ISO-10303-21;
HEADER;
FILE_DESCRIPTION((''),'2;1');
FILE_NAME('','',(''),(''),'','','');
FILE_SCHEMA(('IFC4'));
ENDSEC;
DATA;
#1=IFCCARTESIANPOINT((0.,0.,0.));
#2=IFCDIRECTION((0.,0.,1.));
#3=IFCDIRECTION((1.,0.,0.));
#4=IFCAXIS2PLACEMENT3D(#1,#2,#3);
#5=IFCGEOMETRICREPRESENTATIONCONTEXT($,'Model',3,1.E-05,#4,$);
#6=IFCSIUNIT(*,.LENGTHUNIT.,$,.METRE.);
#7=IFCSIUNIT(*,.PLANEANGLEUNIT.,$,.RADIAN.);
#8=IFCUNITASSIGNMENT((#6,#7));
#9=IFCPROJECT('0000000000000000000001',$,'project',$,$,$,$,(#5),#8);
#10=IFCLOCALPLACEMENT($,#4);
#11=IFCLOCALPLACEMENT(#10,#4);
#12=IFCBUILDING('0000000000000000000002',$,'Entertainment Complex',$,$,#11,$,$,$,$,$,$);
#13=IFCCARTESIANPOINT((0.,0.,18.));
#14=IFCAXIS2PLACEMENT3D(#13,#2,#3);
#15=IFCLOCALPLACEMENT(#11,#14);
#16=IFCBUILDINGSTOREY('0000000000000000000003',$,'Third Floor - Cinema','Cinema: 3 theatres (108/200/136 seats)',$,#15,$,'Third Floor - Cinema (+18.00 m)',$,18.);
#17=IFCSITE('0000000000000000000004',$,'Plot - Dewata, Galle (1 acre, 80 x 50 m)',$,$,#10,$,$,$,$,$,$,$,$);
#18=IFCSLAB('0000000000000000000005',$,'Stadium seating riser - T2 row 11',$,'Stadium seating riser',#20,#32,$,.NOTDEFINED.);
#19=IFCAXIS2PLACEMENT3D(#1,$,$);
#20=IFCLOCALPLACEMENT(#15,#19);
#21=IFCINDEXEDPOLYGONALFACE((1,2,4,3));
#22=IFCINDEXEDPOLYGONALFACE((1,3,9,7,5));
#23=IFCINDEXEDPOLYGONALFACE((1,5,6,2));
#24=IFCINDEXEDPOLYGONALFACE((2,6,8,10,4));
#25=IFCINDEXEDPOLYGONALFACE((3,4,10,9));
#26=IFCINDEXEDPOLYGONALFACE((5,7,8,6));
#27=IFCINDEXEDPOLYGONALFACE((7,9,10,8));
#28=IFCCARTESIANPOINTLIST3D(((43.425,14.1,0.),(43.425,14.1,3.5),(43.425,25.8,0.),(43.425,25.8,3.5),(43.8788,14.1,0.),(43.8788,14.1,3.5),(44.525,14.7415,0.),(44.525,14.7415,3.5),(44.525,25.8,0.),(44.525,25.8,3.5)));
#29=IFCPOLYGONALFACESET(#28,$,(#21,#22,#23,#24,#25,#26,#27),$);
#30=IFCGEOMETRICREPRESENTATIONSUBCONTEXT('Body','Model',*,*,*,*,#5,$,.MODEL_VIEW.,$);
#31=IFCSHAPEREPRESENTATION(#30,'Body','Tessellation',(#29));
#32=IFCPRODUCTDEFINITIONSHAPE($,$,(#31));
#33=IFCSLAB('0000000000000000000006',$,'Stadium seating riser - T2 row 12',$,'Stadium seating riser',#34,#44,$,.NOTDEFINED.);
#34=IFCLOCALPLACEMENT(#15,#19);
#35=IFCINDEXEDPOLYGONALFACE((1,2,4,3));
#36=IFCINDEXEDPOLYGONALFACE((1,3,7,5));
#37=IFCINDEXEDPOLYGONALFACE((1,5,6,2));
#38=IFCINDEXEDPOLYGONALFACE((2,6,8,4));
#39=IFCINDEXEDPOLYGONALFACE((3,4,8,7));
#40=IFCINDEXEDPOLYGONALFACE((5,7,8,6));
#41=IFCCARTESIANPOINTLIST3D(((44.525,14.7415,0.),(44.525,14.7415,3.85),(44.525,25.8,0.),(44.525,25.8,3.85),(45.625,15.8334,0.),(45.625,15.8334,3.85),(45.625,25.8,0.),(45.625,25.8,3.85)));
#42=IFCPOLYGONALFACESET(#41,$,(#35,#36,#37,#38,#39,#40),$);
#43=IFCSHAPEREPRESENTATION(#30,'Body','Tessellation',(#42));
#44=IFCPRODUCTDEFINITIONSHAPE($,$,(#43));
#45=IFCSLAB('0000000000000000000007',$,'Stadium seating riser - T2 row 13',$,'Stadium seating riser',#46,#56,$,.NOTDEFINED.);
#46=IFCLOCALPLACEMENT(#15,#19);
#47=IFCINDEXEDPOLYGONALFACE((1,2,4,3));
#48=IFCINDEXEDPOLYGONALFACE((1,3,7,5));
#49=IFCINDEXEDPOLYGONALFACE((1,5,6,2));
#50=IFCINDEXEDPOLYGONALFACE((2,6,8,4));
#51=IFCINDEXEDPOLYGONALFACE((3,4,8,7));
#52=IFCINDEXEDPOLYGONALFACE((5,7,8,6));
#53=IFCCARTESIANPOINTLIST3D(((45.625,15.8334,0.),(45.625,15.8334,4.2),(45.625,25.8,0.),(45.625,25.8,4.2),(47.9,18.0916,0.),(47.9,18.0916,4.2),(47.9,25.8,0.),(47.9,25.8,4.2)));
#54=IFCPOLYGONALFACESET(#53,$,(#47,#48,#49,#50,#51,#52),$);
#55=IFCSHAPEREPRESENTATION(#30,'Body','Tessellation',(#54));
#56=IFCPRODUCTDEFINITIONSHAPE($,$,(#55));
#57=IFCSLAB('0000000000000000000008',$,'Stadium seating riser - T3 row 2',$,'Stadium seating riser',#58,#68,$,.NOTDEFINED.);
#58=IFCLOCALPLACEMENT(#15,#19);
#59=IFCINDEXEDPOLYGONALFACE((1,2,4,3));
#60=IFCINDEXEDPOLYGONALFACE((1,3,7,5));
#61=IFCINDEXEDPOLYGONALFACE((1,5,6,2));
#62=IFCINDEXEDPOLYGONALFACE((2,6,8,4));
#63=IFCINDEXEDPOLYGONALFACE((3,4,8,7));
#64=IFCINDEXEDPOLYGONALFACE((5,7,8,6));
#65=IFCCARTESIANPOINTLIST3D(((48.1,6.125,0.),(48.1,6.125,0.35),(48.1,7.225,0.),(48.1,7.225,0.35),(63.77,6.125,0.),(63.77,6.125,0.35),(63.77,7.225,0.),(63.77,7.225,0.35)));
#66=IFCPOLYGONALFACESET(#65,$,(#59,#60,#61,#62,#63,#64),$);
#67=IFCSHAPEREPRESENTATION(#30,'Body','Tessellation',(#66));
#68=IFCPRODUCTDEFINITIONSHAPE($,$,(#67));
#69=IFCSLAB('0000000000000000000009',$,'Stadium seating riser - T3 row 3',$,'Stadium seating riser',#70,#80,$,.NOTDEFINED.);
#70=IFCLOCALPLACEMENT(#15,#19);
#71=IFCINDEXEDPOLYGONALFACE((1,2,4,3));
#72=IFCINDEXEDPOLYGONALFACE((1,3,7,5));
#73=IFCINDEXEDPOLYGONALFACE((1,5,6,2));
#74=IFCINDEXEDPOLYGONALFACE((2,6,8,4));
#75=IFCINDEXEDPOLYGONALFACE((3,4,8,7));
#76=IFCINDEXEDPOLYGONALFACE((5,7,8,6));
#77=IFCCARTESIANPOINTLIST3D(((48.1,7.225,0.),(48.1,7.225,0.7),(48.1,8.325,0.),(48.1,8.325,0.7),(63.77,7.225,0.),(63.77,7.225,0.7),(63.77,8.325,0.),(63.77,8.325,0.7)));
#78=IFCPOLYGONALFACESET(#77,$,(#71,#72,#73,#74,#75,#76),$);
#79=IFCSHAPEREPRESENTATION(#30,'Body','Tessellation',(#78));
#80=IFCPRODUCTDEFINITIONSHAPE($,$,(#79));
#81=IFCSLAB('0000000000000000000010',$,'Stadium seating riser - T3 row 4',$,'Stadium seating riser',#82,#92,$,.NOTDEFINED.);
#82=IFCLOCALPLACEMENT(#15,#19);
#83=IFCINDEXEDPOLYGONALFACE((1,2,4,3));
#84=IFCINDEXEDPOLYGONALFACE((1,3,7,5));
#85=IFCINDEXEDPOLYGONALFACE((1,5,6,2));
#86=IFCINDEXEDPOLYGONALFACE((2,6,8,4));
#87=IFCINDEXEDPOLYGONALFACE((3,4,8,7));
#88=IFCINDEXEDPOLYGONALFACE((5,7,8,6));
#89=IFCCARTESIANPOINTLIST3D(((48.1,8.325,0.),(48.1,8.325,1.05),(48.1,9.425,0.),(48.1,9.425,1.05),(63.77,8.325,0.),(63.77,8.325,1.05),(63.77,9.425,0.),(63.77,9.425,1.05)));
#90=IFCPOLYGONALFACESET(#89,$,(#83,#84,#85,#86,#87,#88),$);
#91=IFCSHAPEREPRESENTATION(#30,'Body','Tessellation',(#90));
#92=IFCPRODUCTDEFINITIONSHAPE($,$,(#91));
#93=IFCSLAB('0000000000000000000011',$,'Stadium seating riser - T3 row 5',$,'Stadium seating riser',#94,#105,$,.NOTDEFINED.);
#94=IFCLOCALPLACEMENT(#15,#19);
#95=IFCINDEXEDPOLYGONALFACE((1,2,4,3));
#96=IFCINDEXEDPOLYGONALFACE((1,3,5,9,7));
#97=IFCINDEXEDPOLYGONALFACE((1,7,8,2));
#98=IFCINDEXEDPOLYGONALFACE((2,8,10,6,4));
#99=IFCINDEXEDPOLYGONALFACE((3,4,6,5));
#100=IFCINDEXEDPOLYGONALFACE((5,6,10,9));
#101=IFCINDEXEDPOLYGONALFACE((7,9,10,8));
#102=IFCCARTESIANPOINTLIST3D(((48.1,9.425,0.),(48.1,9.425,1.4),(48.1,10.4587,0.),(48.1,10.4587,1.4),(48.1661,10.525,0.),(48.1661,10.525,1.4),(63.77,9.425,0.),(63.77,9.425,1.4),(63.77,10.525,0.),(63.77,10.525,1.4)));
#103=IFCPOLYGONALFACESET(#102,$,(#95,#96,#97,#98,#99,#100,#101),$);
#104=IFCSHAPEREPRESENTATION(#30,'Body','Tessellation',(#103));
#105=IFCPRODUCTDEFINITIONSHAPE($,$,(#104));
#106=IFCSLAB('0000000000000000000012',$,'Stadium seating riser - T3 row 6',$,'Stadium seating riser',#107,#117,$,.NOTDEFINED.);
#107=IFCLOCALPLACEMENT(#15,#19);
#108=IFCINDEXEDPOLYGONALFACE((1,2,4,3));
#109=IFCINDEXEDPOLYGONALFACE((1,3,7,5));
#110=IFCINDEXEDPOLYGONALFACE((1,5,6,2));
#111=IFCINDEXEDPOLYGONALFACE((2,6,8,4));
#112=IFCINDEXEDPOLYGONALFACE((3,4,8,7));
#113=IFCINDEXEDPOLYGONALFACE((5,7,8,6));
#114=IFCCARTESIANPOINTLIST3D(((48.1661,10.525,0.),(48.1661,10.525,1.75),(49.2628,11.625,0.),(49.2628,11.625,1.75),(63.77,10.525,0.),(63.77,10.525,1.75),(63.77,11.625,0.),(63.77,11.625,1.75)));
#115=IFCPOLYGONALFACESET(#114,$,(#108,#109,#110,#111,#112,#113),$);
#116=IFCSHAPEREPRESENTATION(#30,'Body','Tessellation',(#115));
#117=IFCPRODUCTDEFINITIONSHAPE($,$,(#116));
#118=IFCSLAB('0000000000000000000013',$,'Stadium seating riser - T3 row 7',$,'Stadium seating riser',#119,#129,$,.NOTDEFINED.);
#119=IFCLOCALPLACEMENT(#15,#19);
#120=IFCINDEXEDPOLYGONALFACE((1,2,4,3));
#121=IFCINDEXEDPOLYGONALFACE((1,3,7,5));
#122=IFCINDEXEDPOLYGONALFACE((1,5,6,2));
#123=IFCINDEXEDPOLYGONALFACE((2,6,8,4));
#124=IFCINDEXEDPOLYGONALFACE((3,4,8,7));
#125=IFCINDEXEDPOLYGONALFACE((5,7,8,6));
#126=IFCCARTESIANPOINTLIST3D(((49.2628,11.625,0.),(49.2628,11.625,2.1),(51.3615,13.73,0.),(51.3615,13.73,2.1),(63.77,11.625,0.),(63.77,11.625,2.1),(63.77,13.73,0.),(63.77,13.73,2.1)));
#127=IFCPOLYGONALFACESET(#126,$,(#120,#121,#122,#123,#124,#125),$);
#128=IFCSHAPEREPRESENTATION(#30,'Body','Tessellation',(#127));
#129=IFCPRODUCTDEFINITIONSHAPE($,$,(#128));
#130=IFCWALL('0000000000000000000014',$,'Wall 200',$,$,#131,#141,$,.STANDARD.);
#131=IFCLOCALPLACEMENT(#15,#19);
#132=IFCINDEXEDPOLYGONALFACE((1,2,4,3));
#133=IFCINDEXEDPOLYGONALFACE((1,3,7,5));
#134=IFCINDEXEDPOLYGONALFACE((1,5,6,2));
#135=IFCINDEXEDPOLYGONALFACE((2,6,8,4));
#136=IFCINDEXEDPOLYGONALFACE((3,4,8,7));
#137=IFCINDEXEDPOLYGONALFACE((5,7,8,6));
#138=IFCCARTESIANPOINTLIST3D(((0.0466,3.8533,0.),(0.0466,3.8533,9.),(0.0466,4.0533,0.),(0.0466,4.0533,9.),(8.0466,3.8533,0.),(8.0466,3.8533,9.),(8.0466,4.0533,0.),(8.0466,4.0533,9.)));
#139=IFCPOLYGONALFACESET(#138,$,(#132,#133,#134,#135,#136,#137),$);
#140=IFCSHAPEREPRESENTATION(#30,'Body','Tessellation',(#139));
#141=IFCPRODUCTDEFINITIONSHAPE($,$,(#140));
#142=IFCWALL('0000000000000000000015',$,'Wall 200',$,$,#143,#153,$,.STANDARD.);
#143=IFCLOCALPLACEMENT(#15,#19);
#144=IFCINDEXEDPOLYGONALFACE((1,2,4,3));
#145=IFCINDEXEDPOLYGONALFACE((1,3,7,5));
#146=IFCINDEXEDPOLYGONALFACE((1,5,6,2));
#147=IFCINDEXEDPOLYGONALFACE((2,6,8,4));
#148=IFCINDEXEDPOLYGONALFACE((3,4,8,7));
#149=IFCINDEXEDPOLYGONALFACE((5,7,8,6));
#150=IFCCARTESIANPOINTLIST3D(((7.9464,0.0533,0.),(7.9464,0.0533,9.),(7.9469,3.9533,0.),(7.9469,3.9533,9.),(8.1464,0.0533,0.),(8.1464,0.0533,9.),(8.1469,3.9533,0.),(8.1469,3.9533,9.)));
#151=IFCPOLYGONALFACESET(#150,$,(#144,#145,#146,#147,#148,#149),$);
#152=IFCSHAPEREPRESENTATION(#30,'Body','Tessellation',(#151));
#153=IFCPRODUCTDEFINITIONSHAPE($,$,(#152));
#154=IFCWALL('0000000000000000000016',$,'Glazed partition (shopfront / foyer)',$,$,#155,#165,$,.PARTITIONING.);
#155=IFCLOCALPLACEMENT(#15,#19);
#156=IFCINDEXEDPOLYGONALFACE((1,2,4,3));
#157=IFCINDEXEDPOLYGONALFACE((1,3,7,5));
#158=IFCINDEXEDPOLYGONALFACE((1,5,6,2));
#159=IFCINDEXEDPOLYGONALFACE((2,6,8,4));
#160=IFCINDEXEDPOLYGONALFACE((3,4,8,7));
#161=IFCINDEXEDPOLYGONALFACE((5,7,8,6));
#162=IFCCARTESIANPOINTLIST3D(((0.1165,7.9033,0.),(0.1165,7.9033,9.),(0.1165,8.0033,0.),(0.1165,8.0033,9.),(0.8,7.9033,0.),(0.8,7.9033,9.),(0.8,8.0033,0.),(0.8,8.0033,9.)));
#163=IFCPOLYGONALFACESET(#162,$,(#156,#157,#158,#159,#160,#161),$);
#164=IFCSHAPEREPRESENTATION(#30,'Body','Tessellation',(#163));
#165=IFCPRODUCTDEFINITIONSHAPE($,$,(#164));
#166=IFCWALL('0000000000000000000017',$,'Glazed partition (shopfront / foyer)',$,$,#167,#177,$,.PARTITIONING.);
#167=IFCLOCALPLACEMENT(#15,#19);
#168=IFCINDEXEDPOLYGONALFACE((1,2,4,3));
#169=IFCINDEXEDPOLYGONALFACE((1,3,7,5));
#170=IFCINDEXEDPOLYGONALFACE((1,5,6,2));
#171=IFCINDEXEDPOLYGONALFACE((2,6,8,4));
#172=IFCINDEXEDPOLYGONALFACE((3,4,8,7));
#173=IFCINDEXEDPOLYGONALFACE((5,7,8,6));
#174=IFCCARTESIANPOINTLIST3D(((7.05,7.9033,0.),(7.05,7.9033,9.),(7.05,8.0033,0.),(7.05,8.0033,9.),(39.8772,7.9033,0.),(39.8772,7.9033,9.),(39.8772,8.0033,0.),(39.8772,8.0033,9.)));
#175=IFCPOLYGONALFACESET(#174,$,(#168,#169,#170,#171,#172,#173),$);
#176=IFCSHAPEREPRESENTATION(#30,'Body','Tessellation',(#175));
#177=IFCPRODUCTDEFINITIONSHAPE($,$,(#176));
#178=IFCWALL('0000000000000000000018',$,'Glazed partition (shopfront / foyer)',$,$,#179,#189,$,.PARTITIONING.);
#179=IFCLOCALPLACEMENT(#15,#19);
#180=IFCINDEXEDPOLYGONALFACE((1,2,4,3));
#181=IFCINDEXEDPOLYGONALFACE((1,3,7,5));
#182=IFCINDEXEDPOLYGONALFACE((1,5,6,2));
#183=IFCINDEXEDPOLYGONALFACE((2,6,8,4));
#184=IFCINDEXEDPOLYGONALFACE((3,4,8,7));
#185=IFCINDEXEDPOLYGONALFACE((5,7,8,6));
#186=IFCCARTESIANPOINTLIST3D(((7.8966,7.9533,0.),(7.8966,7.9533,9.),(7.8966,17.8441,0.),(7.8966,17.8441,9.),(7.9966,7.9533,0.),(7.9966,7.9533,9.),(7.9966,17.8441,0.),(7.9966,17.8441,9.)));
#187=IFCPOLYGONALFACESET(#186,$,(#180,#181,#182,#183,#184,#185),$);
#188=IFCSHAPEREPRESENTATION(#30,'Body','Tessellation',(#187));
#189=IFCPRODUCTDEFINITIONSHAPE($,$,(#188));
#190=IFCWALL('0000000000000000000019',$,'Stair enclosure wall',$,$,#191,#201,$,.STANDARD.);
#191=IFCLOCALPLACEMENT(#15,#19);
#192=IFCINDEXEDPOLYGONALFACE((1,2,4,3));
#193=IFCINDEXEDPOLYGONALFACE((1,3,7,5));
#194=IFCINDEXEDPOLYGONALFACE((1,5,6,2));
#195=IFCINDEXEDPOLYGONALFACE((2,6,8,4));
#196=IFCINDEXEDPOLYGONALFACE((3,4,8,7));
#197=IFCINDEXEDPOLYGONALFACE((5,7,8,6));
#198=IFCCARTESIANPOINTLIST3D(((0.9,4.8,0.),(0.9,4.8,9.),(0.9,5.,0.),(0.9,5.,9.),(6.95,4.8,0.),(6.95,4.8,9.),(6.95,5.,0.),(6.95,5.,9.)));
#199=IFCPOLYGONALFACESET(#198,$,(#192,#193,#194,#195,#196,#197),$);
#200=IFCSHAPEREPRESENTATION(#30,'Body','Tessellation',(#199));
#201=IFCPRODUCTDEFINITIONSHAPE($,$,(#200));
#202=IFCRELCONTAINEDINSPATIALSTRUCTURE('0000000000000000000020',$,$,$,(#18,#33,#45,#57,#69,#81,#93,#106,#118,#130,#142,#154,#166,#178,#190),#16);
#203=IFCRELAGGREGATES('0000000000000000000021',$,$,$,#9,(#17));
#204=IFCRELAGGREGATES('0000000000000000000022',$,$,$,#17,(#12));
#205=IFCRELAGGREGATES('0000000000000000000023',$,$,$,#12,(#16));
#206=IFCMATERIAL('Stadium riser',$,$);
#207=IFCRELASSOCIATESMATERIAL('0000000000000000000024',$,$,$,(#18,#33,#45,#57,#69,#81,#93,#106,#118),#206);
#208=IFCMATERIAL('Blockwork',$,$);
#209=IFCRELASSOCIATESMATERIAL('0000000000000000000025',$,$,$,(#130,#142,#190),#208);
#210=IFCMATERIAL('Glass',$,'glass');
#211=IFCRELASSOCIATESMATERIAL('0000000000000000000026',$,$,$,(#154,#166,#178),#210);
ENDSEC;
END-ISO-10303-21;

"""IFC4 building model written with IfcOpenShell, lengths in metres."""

from ifc_helpers import new_model, si_unit, frame, origin_with_axes, place, context, subcontext, project, spatial, polyline, outline, extrude, material, element, save


model = new_model("IFC4")

# Units and contexts
model_context = context("Model", 3, precision=1e-05, world=origin_with_axes())
body_context = subcontext(model_context, "Body", "Model", "MODEL_VIEW")
ifc_project = project(units=[si_unit("LENGTHUNIT", "METRE"), si_unit("PLANEANGLEUNIT", "RADIAN")], contexts=[model_context])

# Site, building, storey
site_placement = place(None, origin_with_axes())
site = spatial("IfcSite", under=ifc_project, at=site_placement, Name="Plot - Dewata, Galle (1 acre, 80 x 50 m)")
building_placement = place(site_placement, origin_with_axes())
building = spatial("IfcBuilding", under=site, at=building_placement, Name="Entertainment Complex")
storey_placement = place(building_placement, frame((0.0, 0.0, 18.0), z_axis=(0.0, 0.0, 1.0), x_axis=(1.0, 0.0, 0.0)))
storey = spatial("IfcBuildingStorey", under=building, at=storey_placement, Name="Third Floor - Cinema", Description="Cinema: 3 theatres (108/200/136 seats)", LongName="Third Floor - Cinema (+18.00 m)", Elevation=18.0)

# Slabs
ifc_material_1 = material(Name="Stadium riser")
slab_1_placement = place(storey_placement, origin_with_axes())
element("IfcSlab", 1, at=slab_1_placement, inside=storey, material=ifc_material_1, Name="Stadium seating riser - T2 row 11", ObjectType="Stadium seating riser", PredefinedType="NOTDEFINED", context=body_context, shape_type="SweptSolid", body=[
    extrude(outline(polyline([(43.425, 25.8), (43.425, 14.1), (43.8788, 14.1), (44.525, 14.7415), (44.525, 25.8), (43.425, 25.8)])), origin_with_axes(), (0.0, 0.0, 1.0), 3.5),
])
slab_2_placement = place(storey_placement, origin_with_axes())
element("IfcSlab", 2, at=slab_2_placement, inside=storey, material=ifc_material_1, Name="Stadium seating riser - T2 row 12", ObjectType="Stadium seating riser", PredefinedType="NOTDEFINED", context=body_context, shape_type="SweptSolid", body=[
    extrude(outline(polyline([(44.525, 25.8), (44.525, 14.7415), (45.625, 15.8334), (45.625, 25.8), (44.525, 25.8)])), origin_with_axes(), (0.0, 0.0, 1.0), 3.85),
])
slab_3_placement = place(storey_placement, origin_with_axes())
element("IfcSlab", 3, at=slab_3_placement, inside=storey, material=ifc_material_1, Name="Stadium seating riser - T2 row 13", ObjectType="Stadium seating riser", PredefinedType="NOTDEFINED", context=body_context, shape_type="SweptSolid", body=[
    extrude(outline(polyline([(45.625, 25.8), (45.625, 15.8334), (47.9, 18.0916), (47.9, 25.8), (45.625, 25.8)])), origin_with_axes(), (0.0, 0.0, 1.0), 4.2),
])
slab_4_placement = place(storey_placement, origin_with_axes())
element("IfcSlab", 4, at=slab_4_placement, inside=storey, material=ifc_material_1, Name="Stadium seating riser - T3 row 2", ObjectType="Stadium seating riser", PredefinedType="NOTDEFINED", context=body_context, shape_type="SweptSolid", body=[
    extrude(outline(polyline([(48.1, 6.125), (63.77, 6.125), (63.77, 7.225), (48.1, 7.225), (48.1, 6.125)])), origin_with_axes(), (0.0, 0.0, 1.0), 0.35),
])
slab_5_placement = place(storey_placement, origin_with_axes())
element("IfcSlab", 5, at=slab_5_placement, inside=storey, material=ifc_material_1, Name="Stadium seating riser - T3 row 3", ObjectType="Stadium seating riser", PredefinedType="NOTDEFINED", context=body_context, shape_type="SweptSolid", body=[
    extrude(outline(polyline([(48.1, 7.225), (63.77, 7.225), (63.77, 8.325), (48.1, 8.325), (48.1, 7.225)])), origin_with_axes(), (0.0, 0.0, 1.0), 0.7),
])
slab_6_placement = place(storey_placement, origin_with_axes())
element("IfcSlab", 6, at=slab_6_placement, inside=storey, material=ifc_material_1, Name="Stadium seating riser - T3 row 4", ObjectType="Stadium seating riser", PredefinedType="NOTDEFINED", context=body_context, shape_type="SweptSolid", body=[
    extrude(outline(polyline([(48.1, 8.325), (63.77, 8.325), (63.77, 9.425), (48.1, 9.425), (48.1, 8.325)])), origin_with_axes(), (0.0, 0.0, 1.0), 1.05),
])
slab_7_placement = place(storey_placement, origin_with_axes())
element("IfcSlab", 7, at=slab_7_placement, inside=storey, material=ifc_material_1, Name="Stadium seating riser - T3 row 5", ObjectType="Stadium seating riser", PredefinedType="NOTDEFINED", context=body_context, shape_type="SweptSolid", body=[
    extrude(outline(polyline([(48.1, 9.425), (63.77, 9.425), (63.77, 10.525), (48.1661, 10.525), (48.1, 10.4587), (48.1, 9.425)])), origin_with_axes(), (0.0, 0.0, 1.0), 1.4),
])
slab_8_placement = place(storey_placement, origin_with_axes())
element("IfcSlab", 8, at=slab_8_placement, inside=storey, material=ifc_material_1, Name="Stadium seating riser - T3 row 6", ObjectType="Stadium seating riser", PredefinedType="NOTDEFINED", context=body_context, shape_type="SweptSolid", body=[
    extrude(outline(polyline([(48.1661, 10.525), (63.77, 10.525), (63.77, 11.625), (49.2628, 11.625), (48.1661, 10.525)])), origin_with_axes(), (0.0, 0.0, 1.0), 1.75),
])
slab_9_placement = place(storey_placement, origin_with_axes())
element("IfcSlab", 9, at=slab_9_placement, inside=storey, material=ifc_material_1, Name="Stadium seating riser - T3 row 7", ObjectType="Stadium seating riser", PredefinedType="NOTDEFINED", context=body_context, shape_type="SweptSolid", body=[
    extrude(outline(polyline([(49.2628, 11.625), (63.77, 11.625), (63.77, 13.73), (51.3615, 13.73), (49.2628, 11.625)])), origin_with_axes(), (0.0, 0.0, 1.0), 2.1),
])

# Walls
ifc_material_2 = material(Name="Blockwork")
wall_1_placement = place(storey_placement, frame((0.0466, 3.9533, 0.0), z_axis=(0.0, 0.0, 1.0), x_axis=(1.0, 0.0, 0.0)))
element("IfcWall", 10, at=wall_1_placement, inside=storey, material=ifc_material_2, Name="Wall 200", PredefinedType="STANDARD", context=body_context, shape_type="SweptSolid", body=[
    extrude(outline(polyline([(0.0, -0.1), (8.0, -0.1), (8.0, 0.1), (0.0, 0.1), (0.0, -0.1)])), origin_with_axes(), (0.0, 0.0, 1.0), 9.0),
])
wall_2_placement = place(storey_placement, frame((8.0464, 0.0533, 0.0), z_axis=(0.0, 0.0, 1.0), x_axis=(0.000128, 1.0, 0.0)))
element("IfcWall", 11, at=wall_2_placement, inside=storey, material=ifc_material_2, Name="Wall 200", PredefinedType="STANDARD", context=body_context, shape_type="SweptSolid", body=[
    extrude(outline(polyline([(0.0, -0.1), (3.9, -0.1), (3.9, 0.1), (0.0, 0.1), (0.0, -0.1)])), origin_with_axes(), (0.0, 0.0, 1.0), 9.0),
])
ifc_material_3 = material(Name="Glass", Category="glass")
wall_3_placement = place(storey_placement, frame((0.1165, 7.9533, 0.0), z_axis=(0.0, 0.0, 1.0), x_axis=(1.0, 0.0, 0.0)))
element("IfcWall", 12, at=wall_3_placement, inside=storey, material=ifc_material_3, Name="Glazed partition (shopfront / foyer)", PredefinedType="PARTITIONING", context=body_context, shape_type="SweptSolid", body=[
    extrude(outline(polyline([(0.0, -0.05), (0.6835, -0.05), (0.6835, 0.05), (0.0, 0.05), (0.0, -0.05)])), origin_with_axes(), (0.0, 0.0, 1.0), 9.0),
])
wall_4_placement = place(storey_placement, frame((7.05, 7.9533, 0.0), z_axis=(0.0, 0.0, 1.0), x_axis=(1.0, 0.0, 0.0)))
element("IfcWall", 13, at=wall_4_placement, inside=storey, material=ifc_material_3, Name="Glazed partition (shopfront / foyer)", PredefinedType="PARTITIONING", context=body_context, shape_type="SweptSolid", body=[
    extrude(outline(polyline([(0.0, -0.05), (32.8272, -0.05), (32.8272, 0.05), (0.0, 0.05), (0.0, -0.05)])), origin_with_axes(), (0.0, 0.0, 1.0), 9.0),
])
wall_5_placement = place(storey_placement, frame((7.9466, 7.9533, 0.0), z_axis=(0.0, 0.0, 1.0), x_axis=(0.0, 1.0, 0.0)))
element("IfcWall", 14, at=wall_5_placement, inside=storey, material=ifc_material_3, Name="Glazed partition (shopfront / foyer)", PredefinedType="PARTITIONING", context=body_context, shape_type="SweptSolid", body=[
    extrude(outline(polyline([(0.0, -0.05), (9.8908, -0.05), (9.8908, 0.05), (0.0, 0.05), (0.0, -0.05)])), origin_with_axes(), (0.0, 0.0, 1.0), 9.0),
])
wall_6_placement = place(storey_placement, frame((0.9, 4.9, 0.0), z_axis=(0.0, 0.0, 1.0), x_axis=(1.0, 0.0, 0.0)))
element("IfcWall", 15, at=wall_6_placement, inside=storey, material=ifc_material_2, Name="Stair enclosure wall", PredefinedType="STANDARD", context=body_context, shape_type="SweptSolid", body=[
    extrude(outline(polyline([(0.0, -0.1), (6.05, -0.1), (6.05, 0.1), (0.0, 0.1), (0.0, -0.1)])), origin_with_axes(), (0.0, 0.0, 1.0), 9.0),
])

save(model, "model.ifc")
